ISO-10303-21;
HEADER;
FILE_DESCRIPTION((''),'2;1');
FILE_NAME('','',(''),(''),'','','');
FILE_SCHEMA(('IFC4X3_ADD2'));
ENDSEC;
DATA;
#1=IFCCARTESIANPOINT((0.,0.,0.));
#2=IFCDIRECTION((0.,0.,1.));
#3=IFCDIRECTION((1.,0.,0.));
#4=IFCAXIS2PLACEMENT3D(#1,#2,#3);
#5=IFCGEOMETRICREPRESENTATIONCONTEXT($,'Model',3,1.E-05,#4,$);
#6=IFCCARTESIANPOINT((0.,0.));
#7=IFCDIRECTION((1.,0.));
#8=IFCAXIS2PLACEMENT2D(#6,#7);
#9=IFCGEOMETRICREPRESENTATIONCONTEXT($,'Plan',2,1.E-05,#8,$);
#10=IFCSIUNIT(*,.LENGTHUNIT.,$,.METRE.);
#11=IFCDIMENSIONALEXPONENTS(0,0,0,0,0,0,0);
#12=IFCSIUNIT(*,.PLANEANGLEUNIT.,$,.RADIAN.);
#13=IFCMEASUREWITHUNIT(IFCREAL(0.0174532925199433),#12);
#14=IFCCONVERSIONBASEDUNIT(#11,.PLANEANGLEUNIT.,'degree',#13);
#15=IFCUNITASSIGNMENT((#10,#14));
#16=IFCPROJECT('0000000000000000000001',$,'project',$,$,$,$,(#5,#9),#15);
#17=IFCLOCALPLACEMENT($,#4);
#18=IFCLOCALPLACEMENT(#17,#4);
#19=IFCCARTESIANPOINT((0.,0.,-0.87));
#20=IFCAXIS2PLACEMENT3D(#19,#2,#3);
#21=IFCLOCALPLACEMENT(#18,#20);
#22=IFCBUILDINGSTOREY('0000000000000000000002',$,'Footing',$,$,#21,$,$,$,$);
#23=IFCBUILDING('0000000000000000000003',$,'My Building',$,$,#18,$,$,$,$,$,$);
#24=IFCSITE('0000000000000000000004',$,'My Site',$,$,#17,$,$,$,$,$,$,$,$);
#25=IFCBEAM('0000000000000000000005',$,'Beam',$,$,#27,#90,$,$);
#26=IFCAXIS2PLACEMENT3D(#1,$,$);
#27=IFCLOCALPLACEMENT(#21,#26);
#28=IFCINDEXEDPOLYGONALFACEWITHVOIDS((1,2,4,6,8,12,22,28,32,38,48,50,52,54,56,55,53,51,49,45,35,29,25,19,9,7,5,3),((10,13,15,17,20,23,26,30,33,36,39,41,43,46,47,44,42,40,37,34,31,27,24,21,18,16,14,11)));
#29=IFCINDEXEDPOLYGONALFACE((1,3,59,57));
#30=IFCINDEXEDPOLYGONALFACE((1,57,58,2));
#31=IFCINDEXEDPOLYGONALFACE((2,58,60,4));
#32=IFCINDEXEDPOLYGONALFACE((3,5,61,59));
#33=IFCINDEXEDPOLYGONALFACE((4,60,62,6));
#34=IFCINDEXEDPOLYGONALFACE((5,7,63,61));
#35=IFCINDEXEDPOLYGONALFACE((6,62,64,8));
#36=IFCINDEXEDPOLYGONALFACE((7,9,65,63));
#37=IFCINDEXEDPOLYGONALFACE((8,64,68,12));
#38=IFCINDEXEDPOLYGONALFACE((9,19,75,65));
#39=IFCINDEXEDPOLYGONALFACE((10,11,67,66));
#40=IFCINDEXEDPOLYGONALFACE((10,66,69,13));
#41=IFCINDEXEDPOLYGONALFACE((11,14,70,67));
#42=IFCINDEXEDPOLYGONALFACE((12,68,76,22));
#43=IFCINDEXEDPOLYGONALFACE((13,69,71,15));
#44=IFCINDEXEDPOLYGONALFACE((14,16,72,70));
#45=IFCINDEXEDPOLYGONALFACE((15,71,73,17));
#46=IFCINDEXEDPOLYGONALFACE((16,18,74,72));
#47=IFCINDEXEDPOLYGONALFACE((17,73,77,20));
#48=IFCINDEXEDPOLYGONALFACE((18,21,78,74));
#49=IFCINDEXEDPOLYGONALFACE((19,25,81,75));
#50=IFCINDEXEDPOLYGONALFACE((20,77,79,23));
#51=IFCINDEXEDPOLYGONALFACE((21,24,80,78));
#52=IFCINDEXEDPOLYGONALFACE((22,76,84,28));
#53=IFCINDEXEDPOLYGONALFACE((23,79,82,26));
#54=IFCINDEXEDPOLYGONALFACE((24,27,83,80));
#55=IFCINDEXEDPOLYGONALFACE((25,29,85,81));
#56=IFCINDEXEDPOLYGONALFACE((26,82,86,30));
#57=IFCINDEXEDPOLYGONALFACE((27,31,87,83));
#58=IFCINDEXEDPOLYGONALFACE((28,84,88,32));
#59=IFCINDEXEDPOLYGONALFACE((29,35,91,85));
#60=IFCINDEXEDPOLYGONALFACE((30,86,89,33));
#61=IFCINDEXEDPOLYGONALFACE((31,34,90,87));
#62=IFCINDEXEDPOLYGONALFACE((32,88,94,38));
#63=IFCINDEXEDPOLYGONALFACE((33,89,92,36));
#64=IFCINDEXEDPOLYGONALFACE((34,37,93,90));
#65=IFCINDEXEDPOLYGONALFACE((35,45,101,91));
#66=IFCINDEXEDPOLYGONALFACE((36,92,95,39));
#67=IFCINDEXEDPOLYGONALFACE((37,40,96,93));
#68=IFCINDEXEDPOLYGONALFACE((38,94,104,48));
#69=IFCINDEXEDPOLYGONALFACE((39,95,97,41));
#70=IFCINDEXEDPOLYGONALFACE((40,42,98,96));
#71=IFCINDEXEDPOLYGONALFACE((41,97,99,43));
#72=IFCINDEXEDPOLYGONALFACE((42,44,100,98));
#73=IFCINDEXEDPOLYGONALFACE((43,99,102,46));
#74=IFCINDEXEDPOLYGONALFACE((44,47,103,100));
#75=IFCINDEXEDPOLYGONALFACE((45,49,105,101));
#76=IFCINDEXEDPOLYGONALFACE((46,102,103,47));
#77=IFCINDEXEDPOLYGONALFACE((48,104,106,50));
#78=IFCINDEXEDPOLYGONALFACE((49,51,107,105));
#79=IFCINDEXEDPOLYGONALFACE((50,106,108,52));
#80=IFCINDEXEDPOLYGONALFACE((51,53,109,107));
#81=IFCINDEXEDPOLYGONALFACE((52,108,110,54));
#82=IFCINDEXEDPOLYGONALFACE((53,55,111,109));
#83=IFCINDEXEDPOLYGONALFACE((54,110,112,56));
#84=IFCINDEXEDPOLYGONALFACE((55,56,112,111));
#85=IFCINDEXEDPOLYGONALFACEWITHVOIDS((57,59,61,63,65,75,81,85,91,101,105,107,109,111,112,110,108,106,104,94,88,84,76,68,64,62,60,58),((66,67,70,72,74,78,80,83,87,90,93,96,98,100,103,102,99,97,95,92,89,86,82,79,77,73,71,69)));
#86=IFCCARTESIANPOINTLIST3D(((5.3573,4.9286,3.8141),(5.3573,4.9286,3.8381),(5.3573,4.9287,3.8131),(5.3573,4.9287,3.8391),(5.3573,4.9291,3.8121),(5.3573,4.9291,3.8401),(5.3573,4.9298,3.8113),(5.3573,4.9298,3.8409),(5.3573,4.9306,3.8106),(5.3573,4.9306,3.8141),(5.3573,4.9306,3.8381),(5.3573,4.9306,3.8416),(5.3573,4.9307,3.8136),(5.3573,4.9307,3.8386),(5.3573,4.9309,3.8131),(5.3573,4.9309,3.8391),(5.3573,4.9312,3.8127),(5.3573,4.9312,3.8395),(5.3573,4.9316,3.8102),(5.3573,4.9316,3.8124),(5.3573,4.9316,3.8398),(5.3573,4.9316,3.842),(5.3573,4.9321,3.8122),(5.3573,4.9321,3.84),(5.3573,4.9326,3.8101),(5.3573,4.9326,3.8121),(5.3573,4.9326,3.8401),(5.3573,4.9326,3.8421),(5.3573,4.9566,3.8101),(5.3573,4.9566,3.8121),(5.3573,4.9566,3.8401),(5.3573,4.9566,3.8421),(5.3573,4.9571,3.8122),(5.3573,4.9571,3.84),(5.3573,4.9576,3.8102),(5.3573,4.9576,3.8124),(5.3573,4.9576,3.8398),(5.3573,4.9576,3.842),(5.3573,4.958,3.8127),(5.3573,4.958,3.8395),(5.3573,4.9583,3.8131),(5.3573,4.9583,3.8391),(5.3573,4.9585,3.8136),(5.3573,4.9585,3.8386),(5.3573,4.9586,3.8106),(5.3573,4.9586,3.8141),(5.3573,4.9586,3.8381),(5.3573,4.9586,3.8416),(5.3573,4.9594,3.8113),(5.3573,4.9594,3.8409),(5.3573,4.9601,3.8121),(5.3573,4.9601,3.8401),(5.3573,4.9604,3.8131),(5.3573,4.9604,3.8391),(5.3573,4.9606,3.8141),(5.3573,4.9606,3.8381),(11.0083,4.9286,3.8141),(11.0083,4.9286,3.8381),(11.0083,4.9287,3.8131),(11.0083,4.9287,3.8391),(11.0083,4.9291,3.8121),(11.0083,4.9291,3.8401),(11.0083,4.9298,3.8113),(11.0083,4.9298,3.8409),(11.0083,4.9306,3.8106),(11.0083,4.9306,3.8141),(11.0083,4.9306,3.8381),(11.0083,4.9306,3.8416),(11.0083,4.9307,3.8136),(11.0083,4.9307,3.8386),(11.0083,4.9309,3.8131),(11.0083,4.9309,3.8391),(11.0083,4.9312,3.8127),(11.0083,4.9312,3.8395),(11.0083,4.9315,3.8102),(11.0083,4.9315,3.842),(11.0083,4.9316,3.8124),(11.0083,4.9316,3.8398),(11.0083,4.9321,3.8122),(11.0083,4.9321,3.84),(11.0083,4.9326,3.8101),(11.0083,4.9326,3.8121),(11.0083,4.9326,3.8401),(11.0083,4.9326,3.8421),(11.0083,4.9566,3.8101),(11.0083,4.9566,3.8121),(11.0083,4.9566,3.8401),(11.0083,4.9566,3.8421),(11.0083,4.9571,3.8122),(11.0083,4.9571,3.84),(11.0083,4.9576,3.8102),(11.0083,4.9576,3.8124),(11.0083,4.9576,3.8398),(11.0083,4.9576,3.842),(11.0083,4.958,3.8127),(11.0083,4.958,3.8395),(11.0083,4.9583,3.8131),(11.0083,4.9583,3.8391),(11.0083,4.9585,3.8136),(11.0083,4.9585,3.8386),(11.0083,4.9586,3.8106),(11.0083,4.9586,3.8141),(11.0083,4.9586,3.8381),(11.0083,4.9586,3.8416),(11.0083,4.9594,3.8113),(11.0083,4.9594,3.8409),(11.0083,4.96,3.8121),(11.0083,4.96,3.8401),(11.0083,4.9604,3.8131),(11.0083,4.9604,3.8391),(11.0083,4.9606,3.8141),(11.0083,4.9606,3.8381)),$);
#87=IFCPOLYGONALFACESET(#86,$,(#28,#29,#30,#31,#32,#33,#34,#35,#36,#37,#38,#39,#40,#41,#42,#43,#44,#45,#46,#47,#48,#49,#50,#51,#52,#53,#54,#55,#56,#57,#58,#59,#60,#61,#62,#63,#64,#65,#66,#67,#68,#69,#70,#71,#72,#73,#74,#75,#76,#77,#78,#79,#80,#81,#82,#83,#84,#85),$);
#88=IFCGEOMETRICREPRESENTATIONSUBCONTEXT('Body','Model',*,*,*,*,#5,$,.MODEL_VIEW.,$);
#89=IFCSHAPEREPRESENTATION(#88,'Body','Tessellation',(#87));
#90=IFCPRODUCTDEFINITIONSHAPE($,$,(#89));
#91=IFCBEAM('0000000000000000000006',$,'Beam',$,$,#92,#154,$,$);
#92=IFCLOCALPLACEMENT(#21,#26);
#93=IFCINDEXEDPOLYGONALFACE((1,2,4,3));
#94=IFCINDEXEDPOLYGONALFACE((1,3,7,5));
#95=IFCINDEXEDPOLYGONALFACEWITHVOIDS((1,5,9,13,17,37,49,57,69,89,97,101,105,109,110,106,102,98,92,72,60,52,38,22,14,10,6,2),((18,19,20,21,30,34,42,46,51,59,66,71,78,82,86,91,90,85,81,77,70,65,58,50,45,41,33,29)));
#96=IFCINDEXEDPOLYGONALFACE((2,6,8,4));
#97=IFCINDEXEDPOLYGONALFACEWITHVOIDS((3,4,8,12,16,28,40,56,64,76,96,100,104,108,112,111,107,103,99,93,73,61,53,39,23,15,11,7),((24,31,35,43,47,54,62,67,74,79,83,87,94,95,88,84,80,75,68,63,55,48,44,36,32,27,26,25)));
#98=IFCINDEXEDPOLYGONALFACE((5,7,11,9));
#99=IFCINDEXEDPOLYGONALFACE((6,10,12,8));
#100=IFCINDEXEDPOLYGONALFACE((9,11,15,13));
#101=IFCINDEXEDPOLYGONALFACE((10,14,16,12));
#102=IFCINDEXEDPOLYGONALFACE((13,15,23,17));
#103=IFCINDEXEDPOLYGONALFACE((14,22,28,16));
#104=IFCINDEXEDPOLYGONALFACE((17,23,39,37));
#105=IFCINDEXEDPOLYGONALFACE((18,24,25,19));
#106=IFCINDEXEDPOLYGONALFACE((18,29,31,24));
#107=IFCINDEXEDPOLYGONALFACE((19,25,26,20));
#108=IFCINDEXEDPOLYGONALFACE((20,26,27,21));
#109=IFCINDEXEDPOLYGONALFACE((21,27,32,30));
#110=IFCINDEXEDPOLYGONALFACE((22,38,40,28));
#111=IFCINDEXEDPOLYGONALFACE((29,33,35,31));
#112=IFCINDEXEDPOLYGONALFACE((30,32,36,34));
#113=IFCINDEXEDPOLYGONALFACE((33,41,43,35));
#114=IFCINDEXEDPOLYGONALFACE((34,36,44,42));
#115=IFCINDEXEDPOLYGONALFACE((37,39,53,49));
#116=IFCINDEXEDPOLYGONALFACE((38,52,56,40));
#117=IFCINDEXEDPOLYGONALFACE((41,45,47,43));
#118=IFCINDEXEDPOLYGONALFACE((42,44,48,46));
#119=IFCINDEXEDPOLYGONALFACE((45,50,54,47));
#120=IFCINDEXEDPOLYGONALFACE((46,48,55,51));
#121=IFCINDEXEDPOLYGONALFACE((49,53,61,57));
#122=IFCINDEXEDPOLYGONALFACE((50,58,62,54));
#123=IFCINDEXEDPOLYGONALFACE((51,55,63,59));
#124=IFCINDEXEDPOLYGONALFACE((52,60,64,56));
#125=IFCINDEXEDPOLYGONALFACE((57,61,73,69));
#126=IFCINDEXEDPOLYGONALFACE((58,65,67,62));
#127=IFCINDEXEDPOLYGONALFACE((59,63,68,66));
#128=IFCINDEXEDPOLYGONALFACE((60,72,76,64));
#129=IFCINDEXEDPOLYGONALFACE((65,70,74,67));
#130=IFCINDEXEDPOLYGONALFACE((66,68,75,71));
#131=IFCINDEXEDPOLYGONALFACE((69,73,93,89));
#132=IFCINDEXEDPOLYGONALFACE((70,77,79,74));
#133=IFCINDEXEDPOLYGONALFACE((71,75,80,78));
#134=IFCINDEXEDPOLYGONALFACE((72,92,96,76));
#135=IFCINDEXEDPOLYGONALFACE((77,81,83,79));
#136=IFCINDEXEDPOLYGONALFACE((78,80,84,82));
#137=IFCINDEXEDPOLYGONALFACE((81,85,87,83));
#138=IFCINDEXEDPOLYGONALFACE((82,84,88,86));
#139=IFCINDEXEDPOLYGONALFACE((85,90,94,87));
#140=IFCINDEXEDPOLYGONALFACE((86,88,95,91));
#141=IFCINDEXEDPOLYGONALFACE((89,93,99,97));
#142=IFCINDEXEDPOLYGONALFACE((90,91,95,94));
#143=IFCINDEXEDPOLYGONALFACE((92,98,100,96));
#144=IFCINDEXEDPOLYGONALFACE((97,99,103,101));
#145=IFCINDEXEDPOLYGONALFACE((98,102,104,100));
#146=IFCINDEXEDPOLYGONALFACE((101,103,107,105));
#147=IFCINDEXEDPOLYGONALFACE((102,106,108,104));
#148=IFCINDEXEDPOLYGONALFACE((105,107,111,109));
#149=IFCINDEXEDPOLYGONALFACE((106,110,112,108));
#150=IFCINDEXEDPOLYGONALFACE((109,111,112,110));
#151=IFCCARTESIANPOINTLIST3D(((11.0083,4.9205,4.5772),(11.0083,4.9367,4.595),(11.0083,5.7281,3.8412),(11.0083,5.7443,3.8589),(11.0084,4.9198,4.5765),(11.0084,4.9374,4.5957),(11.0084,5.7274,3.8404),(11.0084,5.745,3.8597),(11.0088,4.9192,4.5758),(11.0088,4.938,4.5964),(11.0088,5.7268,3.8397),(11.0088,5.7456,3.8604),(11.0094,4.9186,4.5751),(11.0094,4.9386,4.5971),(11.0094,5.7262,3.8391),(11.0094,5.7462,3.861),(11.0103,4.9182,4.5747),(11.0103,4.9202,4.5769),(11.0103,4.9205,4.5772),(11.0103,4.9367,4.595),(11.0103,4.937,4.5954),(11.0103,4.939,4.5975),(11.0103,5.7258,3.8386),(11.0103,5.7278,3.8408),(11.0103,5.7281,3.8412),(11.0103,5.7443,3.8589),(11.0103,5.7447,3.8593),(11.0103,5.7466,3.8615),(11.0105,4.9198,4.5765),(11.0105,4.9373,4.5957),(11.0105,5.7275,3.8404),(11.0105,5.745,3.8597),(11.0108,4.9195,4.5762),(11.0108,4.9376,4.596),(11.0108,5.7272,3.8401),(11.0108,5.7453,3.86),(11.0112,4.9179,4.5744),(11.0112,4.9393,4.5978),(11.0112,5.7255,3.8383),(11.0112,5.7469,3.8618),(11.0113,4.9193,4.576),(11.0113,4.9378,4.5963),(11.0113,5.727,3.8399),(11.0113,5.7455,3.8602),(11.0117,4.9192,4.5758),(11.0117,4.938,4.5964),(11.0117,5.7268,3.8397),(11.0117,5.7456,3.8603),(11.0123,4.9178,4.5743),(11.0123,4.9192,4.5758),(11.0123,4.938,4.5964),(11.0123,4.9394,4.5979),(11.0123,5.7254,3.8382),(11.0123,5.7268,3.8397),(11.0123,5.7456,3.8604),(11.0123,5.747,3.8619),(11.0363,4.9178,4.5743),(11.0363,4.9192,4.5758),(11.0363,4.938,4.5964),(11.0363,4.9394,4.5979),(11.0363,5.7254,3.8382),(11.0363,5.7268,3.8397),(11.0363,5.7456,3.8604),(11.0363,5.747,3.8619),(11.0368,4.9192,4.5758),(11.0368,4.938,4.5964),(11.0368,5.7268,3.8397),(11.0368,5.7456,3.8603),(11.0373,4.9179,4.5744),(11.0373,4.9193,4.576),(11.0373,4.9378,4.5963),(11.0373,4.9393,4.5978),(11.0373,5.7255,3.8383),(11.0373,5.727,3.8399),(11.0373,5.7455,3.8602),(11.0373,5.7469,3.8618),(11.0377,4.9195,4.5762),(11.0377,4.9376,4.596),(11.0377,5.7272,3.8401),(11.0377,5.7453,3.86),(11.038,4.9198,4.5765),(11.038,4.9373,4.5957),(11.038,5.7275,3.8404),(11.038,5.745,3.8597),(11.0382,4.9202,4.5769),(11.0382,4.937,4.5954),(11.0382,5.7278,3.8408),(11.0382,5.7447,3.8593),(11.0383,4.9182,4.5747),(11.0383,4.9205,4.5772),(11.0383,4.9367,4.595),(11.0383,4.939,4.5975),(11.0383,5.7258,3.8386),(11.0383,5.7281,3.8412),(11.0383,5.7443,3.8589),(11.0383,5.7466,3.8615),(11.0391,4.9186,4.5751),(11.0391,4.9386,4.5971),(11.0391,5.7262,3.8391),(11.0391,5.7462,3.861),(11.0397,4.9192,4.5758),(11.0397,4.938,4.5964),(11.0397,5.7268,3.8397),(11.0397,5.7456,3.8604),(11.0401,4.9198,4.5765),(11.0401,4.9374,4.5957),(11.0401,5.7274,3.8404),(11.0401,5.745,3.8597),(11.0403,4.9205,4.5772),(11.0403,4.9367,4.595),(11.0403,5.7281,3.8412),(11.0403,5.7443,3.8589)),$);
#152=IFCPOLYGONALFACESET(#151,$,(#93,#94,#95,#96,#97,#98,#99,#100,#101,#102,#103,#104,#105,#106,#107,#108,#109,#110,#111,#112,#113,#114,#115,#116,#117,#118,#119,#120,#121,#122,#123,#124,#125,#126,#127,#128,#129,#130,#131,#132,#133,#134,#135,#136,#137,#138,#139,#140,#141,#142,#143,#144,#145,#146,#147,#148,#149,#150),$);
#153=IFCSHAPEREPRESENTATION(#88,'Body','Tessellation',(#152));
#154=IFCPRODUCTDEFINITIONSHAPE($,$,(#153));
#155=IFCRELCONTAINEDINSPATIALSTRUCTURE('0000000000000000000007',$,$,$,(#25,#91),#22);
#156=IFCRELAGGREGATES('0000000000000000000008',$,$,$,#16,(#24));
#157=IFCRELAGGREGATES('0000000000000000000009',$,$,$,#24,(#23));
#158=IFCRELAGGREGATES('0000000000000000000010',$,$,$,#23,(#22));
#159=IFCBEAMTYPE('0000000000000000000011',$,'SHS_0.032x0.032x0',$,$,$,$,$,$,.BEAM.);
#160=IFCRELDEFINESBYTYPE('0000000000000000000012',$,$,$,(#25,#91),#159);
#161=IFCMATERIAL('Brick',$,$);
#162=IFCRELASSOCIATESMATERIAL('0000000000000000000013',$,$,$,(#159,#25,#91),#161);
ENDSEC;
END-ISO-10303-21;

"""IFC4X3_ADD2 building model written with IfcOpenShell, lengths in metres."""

from ifc_helpers import new_model, entity, si_unit, converted_unit, frame, origin_with_axes, origin_2d_with_axis, place, context, subcontext, project, spatial, hollow_rectangle, extrude, material, material_profile, profile_set, profile_usage, type_object, element, save


model = new_model("IFC4X3_ADD2")

# Units and contexts
model_context = context("Model", 3, precision=1e-05, world=origin_with_axes())
plan_context = context("Plan", 2, precision=1e-05, world=origin_2d_with_axis())
body_context = subcontext(model_context, "Body", "Model", "MODEL_VIEW")
ifc_project = project(units=[si_unit("LENGTHUNIT", "METRE"), converted_unit("PLANEANGLEUNIT", "degree", entity("IfcReal", 0.0174532925199433), si_unit("PLANEANGLEUNIT", "RADIAN"), dimensions=[0, 0, 0, 0, 0, 0, 0])], contexts=[model_context, plan_context])

# Site, building, storey
site_placement = place(None, origin_with_axes())
site = spatial("IfcSite", under=ifc_project, at=site_placement, Name="My Site")
building_placement = place(site_placement, origin_with_axes())
building = spatial("IfcBuilding", under=site, at=building_placement, Name="My Building")
storey_placement = place(building_placement, frame((0.0, 0.0, -0.87), z_axis=(0.0, 0.0, 1.0), x_axis=(1.0, 0.0, 0.0)))
storey = spatial("IfcBuildingStorey", under=building, at=storey_placement, Name="Footing")

# Beams
ifc_material_1 = material(Name="Brick")
ifc_material_profile = material_profile(ifc_material_1, hollow_rectangle(XDim=0.032, YDim=0.032, WallThickness=0.002, InnerFilletRadius=0.002, OuterFilletRadius=0.004))
ifc_profile_set = profile_set([ifc_material_profile])
beam_type_1 = type_object("IfcBeamType", Name="SHS_0.032x0.032x0", PredefinedType="BEAM", material=ifc_profile_set)
ifc_profile_usage_1 = profile_usage(ifc_profile_set, cardinal=5)
beam_1_placement = place(storey_placement, frame((5.3573, 4.9446, 3.8261), z_axis=(1.0, 0.0, 0.0), x_axis=(0.0, 1.0, 0.0)))
element("IfcBeam", 1, at=beam_1_placement, inside=storey, type_object=beam_type_1, material=ifc_profile_usage_1, Name="Beam", context=body_context, shape_type="SweptSolid", body=[
    extrude(hollow_rectangle(XDim=0.032, YDim=0.032, WallThickness=0.002, InnerFilletRadius=0.002, OuterFilletRadius=0.004), origin_with_axes(), (0.0, 0.0, 1.0), 5.651),
])
ifc_profile_usage_2 = profile_usage(ifc_profile_set, cardinal=5)
beam_2_placement = place(storey_placement, frame((11.0243, 4.9286, 4.5861), z_axis=(0.0, 0.739099, -0.673597), x_axis=(-1.0, 0.0, 0.0)))
element("IfcBeam", 2, at=beam_2_placement, inside=storey, type_object=beam_type_1, material=ifc_profile_usage_2, Name="Beam", context=body_context, shape_type="SweptSolid", body=[
    extrude(hollow_rectangle(XDim=0.032, YDim=0.032, WallThickness=0.002, InnerFilletRadius=0.002, OuterFilletRadius=0.004), origin_with_axes(), (0.0, 0.0, 1.0), 1.0927),
])

save(model, "model.ifc")
